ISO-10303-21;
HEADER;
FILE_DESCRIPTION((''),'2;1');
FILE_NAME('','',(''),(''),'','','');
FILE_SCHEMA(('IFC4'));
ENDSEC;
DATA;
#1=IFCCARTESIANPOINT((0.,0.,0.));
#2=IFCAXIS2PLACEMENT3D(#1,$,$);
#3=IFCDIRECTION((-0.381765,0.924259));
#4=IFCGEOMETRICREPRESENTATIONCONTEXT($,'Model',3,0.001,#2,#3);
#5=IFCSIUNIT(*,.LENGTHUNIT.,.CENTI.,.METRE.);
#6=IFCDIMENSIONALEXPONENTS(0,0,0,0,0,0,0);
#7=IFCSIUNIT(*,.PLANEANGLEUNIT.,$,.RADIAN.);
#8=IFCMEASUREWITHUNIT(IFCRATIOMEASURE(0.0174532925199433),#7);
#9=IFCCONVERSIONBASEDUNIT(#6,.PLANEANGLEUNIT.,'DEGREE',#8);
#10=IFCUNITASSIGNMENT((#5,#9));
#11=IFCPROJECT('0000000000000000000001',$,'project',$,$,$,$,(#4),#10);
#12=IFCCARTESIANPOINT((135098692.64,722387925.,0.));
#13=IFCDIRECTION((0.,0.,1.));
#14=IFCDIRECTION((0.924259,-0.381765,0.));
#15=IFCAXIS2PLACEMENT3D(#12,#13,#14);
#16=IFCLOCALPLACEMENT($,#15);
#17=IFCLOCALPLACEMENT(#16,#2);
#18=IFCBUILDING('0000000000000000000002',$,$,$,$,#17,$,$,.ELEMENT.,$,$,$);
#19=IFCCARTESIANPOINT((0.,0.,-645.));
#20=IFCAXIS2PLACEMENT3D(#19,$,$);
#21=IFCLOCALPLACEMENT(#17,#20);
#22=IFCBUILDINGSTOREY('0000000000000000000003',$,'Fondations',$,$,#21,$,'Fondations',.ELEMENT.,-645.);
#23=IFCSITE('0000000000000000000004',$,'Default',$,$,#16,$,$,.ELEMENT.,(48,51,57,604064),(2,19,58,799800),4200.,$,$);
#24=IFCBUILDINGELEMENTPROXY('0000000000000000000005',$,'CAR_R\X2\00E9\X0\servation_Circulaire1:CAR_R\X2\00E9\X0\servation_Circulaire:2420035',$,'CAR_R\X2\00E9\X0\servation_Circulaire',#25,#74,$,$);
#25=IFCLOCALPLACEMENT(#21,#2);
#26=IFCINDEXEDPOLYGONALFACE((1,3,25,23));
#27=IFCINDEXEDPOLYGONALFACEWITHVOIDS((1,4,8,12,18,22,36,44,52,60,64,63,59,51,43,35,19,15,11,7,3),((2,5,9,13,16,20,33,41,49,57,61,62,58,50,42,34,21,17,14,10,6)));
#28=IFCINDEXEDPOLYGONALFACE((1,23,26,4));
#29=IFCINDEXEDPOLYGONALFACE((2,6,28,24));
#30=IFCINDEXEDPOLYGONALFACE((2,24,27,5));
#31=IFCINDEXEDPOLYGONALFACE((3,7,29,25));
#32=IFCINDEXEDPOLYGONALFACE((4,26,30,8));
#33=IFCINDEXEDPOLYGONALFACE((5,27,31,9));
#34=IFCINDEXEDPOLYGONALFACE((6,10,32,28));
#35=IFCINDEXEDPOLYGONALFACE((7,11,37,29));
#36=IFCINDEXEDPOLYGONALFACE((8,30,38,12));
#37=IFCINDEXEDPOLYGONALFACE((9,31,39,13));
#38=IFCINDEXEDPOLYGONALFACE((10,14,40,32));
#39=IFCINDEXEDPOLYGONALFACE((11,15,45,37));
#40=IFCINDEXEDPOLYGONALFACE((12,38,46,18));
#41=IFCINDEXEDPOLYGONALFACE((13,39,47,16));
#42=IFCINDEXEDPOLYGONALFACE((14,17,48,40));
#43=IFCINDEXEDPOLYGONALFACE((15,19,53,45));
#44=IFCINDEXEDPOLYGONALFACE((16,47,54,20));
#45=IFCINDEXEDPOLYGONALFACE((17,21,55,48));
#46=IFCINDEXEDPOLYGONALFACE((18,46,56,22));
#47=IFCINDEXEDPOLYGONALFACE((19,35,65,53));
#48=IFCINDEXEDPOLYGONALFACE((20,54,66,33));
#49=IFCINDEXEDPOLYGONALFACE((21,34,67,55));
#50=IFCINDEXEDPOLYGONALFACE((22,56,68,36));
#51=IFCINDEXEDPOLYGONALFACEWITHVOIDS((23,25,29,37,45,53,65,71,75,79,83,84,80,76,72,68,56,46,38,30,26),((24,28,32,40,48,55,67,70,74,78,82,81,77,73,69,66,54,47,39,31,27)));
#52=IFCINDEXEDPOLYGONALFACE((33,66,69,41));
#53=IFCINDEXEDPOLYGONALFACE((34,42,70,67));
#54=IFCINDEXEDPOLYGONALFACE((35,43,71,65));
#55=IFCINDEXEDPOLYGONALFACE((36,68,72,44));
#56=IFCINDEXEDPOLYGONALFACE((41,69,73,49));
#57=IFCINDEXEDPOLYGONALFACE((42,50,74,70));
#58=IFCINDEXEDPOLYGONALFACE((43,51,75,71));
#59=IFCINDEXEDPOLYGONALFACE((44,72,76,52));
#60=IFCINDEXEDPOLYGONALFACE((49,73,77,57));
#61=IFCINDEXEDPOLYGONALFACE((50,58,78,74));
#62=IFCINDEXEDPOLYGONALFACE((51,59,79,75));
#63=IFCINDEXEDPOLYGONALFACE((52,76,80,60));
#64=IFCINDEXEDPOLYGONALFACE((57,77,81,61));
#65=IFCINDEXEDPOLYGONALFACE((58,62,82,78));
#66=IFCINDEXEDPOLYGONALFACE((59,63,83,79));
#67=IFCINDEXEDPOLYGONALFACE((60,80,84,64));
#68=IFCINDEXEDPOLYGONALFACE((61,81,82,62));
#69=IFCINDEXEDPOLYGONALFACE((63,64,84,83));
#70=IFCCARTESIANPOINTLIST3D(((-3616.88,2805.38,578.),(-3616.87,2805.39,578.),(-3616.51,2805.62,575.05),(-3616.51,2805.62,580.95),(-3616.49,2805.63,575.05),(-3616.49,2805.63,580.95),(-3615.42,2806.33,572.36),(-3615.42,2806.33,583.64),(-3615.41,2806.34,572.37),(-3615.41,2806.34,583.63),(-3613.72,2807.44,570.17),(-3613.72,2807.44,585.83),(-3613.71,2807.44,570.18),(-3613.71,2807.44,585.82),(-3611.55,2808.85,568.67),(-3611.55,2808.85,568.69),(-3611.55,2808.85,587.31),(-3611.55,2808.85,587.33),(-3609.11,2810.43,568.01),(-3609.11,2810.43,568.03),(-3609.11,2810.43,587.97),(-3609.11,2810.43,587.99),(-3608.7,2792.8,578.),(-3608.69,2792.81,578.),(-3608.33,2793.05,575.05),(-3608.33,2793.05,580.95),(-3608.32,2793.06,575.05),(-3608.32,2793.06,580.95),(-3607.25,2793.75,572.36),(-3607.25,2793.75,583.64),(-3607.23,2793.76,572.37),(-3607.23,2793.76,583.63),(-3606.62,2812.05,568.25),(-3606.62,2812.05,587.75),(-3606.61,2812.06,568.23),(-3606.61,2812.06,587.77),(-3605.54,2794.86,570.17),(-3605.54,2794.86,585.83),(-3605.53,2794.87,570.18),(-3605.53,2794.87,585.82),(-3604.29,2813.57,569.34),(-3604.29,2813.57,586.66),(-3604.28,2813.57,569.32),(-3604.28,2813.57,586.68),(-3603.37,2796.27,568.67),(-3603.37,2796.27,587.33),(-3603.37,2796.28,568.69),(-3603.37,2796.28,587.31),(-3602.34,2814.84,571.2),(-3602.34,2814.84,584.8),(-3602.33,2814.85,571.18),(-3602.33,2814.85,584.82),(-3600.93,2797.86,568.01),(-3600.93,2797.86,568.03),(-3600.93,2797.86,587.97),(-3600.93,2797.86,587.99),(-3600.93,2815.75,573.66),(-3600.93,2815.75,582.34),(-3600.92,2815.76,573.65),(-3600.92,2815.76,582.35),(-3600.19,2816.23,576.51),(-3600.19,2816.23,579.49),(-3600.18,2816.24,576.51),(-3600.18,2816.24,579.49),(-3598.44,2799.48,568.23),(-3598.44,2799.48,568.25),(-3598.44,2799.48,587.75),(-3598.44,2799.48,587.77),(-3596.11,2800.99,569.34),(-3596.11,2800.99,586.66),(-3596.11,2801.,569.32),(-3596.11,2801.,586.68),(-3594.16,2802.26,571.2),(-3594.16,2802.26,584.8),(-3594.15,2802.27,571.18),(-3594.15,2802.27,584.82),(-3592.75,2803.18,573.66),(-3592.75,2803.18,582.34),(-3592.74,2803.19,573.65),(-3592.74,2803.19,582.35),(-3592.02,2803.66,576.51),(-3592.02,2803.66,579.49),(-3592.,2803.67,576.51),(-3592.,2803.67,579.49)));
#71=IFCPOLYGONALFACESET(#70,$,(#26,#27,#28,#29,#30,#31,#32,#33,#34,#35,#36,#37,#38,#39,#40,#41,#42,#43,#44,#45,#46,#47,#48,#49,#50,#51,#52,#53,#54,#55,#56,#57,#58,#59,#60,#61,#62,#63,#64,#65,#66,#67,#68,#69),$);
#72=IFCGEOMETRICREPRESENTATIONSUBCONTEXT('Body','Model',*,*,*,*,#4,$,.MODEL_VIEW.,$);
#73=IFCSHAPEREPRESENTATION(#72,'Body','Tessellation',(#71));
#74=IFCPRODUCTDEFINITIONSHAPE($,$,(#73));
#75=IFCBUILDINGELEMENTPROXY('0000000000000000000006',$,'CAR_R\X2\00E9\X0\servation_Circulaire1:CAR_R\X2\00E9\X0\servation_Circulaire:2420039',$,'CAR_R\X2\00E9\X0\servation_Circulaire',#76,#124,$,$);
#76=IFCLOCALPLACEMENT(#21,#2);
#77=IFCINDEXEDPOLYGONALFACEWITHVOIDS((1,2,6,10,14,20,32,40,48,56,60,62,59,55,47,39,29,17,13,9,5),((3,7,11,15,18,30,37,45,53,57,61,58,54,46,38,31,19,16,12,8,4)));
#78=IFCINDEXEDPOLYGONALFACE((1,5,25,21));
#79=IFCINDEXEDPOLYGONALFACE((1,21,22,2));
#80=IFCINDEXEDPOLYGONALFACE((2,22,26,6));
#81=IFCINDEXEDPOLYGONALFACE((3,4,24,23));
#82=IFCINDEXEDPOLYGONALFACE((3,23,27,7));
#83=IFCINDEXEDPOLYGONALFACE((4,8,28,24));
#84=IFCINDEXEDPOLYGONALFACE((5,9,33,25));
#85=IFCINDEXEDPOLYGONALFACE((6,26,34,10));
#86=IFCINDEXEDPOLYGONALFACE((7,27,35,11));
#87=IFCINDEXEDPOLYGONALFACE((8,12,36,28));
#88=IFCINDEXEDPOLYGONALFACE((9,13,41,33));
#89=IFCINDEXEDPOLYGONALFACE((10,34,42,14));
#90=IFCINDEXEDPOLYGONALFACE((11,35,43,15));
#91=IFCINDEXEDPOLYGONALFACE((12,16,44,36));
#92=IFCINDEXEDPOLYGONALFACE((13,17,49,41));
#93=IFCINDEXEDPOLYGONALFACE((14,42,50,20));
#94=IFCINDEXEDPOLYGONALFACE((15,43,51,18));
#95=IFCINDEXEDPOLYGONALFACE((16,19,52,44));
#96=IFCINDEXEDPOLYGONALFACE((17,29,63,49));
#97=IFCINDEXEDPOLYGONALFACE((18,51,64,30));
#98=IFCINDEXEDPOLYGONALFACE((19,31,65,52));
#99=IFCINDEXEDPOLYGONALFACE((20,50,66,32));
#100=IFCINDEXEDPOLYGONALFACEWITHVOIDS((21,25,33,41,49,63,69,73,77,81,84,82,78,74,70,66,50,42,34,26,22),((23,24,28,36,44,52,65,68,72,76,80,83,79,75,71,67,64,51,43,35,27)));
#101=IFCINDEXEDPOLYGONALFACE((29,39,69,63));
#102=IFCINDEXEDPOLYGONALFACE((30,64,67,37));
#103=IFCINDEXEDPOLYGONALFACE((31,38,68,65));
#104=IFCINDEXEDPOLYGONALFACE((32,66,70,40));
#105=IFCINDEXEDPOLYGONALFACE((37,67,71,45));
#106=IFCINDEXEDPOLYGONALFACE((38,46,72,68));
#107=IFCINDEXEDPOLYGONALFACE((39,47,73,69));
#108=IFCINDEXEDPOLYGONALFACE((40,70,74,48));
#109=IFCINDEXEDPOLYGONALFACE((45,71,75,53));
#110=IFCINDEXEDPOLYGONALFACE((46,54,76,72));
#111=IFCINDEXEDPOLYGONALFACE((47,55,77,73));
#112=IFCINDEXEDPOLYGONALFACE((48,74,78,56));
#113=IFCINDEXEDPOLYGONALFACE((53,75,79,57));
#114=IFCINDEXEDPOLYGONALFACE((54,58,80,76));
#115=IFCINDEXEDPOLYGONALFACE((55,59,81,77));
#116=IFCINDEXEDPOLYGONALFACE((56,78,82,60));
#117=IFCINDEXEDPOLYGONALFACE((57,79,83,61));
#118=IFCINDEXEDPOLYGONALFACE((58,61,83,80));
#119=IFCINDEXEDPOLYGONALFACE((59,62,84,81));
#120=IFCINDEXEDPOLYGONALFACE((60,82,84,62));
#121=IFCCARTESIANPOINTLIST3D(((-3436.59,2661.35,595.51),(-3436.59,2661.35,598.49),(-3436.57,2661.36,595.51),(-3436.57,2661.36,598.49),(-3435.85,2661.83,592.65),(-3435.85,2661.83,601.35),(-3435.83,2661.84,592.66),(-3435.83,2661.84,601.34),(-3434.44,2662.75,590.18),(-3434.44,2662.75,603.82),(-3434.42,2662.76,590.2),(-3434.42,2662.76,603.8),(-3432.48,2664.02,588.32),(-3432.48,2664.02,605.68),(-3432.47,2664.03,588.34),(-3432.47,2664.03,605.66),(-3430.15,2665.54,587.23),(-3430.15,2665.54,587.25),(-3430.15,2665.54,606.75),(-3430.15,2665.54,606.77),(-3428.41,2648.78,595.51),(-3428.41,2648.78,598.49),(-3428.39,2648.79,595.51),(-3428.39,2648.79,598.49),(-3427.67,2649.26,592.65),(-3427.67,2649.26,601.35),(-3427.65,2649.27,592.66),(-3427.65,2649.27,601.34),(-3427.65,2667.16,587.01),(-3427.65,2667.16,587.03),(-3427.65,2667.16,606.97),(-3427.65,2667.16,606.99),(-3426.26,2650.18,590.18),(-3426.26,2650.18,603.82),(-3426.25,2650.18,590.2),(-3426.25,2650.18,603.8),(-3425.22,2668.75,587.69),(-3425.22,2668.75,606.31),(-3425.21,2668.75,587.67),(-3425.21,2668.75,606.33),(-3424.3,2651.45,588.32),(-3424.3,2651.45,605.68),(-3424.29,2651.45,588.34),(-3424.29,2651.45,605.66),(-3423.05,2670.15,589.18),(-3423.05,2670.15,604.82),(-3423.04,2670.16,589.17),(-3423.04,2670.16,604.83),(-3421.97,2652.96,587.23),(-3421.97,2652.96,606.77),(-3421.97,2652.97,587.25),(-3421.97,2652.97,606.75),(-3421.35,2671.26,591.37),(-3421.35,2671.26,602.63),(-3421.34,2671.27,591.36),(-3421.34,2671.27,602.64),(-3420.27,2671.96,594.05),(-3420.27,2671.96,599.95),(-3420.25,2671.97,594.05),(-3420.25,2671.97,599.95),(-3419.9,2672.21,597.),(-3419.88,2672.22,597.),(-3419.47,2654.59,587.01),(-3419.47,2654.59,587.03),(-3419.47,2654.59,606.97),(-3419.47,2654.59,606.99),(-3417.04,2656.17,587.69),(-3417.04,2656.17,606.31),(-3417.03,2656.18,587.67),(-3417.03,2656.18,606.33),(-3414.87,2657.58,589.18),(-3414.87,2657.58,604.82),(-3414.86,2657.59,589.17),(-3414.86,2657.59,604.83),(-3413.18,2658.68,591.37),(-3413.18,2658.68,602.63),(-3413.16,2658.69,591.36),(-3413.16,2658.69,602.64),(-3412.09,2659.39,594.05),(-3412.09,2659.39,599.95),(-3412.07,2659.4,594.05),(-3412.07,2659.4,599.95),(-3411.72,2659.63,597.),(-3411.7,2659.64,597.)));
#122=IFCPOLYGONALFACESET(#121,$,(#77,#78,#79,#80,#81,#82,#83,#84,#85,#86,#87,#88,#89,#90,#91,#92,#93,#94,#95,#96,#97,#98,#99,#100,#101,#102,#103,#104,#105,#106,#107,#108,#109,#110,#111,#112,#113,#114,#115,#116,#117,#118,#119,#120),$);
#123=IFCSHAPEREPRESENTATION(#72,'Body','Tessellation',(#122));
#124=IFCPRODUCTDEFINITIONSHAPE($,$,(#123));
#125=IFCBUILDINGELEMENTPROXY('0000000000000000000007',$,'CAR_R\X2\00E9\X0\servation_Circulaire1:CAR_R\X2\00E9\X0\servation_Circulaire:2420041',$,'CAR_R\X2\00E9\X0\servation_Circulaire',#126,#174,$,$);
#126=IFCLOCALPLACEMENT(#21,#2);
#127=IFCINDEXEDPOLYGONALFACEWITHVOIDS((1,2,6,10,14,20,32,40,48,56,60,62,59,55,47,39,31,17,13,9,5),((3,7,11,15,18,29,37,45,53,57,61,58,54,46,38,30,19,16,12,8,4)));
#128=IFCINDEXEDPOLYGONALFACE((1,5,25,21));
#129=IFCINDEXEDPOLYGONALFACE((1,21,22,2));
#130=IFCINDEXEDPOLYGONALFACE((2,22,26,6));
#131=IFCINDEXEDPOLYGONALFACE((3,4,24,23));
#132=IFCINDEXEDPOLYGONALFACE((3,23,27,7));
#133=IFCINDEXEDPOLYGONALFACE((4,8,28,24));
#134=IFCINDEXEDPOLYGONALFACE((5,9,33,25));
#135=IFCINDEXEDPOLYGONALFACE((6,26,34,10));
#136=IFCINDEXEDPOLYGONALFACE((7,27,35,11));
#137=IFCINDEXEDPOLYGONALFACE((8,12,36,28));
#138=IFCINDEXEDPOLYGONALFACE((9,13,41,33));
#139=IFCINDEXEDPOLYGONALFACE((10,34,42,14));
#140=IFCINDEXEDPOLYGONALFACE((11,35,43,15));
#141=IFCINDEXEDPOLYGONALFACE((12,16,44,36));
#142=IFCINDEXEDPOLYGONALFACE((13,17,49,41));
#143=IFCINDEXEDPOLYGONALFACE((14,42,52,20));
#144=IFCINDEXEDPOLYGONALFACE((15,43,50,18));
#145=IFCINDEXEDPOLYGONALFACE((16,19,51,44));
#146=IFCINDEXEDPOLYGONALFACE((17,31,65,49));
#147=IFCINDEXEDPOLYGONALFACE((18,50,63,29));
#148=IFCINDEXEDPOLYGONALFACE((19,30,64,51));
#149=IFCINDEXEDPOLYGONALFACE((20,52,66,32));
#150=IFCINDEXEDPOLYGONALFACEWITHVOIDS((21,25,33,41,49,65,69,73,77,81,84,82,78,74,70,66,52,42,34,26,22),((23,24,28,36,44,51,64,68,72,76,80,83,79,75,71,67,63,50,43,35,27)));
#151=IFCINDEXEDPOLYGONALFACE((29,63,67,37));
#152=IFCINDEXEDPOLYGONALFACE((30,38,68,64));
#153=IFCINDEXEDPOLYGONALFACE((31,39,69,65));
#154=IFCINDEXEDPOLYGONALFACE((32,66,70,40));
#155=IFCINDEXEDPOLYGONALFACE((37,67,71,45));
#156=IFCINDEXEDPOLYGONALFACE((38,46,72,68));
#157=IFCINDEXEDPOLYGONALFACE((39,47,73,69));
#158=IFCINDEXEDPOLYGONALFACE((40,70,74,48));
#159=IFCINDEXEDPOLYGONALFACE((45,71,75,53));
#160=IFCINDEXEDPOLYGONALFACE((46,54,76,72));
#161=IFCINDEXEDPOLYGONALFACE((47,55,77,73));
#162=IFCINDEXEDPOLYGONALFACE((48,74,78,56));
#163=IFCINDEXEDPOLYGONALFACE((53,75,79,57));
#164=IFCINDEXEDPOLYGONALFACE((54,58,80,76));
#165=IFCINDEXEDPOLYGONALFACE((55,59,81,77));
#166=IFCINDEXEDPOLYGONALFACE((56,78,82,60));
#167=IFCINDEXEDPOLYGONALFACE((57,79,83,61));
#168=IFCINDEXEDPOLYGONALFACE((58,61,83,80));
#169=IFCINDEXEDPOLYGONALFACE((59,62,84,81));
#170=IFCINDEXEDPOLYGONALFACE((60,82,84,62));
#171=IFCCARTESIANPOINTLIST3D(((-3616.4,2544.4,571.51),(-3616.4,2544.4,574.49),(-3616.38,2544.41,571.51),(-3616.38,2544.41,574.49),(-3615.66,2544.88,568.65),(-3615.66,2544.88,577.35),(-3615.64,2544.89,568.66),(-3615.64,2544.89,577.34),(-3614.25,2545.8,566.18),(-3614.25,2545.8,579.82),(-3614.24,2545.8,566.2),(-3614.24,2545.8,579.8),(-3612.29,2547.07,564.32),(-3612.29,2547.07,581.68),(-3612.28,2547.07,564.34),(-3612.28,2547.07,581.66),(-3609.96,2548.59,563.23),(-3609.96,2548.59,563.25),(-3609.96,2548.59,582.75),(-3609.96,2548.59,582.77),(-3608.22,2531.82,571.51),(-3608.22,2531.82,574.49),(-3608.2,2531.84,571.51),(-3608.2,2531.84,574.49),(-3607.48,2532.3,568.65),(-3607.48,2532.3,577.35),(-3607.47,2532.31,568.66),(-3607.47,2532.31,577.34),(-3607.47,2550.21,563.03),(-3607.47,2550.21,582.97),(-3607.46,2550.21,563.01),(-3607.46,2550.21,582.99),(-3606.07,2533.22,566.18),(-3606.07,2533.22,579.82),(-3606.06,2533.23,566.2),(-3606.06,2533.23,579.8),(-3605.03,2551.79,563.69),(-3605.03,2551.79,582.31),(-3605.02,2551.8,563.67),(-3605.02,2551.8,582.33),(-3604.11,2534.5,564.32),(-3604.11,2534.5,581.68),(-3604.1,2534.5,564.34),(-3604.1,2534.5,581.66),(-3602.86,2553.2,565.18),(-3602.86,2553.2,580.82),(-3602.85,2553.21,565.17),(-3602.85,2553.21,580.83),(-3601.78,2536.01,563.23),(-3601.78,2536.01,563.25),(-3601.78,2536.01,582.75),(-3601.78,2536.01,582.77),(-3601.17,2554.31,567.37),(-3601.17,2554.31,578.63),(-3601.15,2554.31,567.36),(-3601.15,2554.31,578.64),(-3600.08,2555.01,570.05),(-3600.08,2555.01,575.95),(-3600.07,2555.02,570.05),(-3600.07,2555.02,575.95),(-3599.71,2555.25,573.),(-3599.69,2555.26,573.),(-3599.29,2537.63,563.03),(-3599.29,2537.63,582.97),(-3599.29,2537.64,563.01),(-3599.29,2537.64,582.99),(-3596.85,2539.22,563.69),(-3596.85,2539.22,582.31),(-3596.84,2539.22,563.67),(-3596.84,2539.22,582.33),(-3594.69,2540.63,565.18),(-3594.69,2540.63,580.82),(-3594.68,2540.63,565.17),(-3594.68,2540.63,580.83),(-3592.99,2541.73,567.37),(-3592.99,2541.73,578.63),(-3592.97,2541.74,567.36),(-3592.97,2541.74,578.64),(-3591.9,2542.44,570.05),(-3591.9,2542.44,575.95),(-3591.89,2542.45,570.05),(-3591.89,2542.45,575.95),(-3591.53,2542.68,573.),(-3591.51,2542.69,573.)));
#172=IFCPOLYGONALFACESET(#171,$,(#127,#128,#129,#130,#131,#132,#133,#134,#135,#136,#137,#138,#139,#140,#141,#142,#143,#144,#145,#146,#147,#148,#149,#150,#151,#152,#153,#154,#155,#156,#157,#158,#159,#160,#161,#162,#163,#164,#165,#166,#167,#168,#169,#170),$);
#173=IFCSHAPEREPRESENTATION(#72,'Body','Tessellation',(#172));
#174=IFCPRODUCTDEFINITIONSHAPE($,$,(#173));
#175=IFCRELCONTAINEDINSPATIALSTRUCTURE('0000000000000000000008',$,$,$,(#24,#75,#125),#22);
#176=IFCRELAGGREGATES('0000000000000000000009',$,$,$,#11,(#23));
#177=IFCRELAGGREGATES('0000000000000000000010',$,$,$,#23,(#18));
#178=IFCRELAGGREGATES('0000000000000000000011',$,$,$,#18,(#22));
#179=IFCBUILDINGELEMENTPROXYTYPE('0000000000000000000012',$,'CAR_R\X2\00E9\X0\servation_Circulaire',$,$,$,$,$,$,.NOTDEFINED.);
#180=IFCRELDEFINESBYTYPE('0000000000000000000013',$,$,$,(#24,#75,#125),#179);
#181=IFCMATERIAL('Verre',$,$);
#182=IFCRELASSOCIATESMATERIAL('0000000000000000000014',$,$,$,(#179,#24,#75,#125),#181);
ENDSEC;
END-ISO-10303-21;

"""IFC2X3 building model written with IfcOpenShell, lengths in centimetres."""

from ifc_helpers import new_model, entity, si_unit, converted_unit, direction, frame, frame_2d, origin, place, context, subcontext, project, spatial, hollow_circle, extrude, source, transform, mapped, material, type_object, type_shapes, element, save


model = new_model("IFC2X3")

# Units and contexts
model_context = context("Model", 3, precision=0.001, world=origin(), true_north=direction((-0.381765, 0.924259)))
body_context = subcontext(model_context, "Body", "Model", "MODEL_VIEW")
ifc_project = project(units=[si_unit("LENGTHUNIT", "METRE", prefix="CENTI"), converted_unit("PLANEANGLEUNIT", "DEGREE", entity("IfcRatioMeasure", 0.0174532925199433), si_unit("PLANEANGLEUNIT", "RADIAN"), dimensions=[0, 0, 0, 0, 0, 0, 0])], contexts=[model_context])

# Site, building, storey
site_placement = place(None, frame((135098692.64, 722387925.0, 0.0), z_axis=(0.0, 0.0, 1.0), x_axis=(0.924259, -0.381765, 0.0)))
site = spatial("IfcSite", under=ifc_project, at=site_placement, Name="Default", CompositionType="ELEMENT", RefLatitude=(48, 51, 57, 604064), RefLongitude=(2, 19, 58, 799800), RefElevation=4200.0)
building_placement = place(site_placement, origin())
building = spatial("IfcBuilding", under=site, at=building_placement, CompositionType="ELEMENT")
storey_placement = place(building_placement, frame((0.0, 0.0, -645.0)))
storey = spatial("IfcBuildingStorey", under=building, at=storey_placement, Name="Fondations", LongName="Fondations", CompositionType="ELEMENT", Elevation=-645.0)

# Building element proxies
ifc_material_1 = material(Name="Verre")
building_element_proxy_type_1 = type_object("IfcBuildingElementProxyType", Name="CAR_Réservation_Circulaire", PredefinedType="NOTDEFINED", material=ifc_material_1)
shared_shape_1 = source(origin(), body_context, "Body", "SweptSolid", [
    extrude(hollow_circle(Radius=10.02, WallThickness=0.02, at=frame_2d((0.0, 0.0), x_axis=(1.0, 0.0))), frame((0.0, 0.0, -15.0)), (0.0, 0.0, 1.0), 15.0),
])
type_shapes(building_element_proxy_type_1, [shared_shape_1])
for number, where, z_axis, x_axis, name in (
    (1, (-3608.48, 2810.84, 578.0), (-0.545236, 0.838282, 0.0), (-0.838282, -0.545236, 0.0), "CAR_Réservation_Circulaire1:CAR_Réservation_Circulaire:2420035"),
    (2, (-3420.1, 2654.18, 597.0), (0.545236, -0.838282, 0.0), (0.838282, 0.545236, 0.0), "CAR_Réservation_Circulaire1:CAR_Réservation_Circulaire:2420039"),
    (3, (-3599.91, 2537.23, 573.0), (0.545236, -0.838282, 0.0), (0.838282, 0.545236, 0.0), "CAR_Réservation_Circulaire1:CAR_Réservation_Circulaire:2420041"),
):
    element("IfcBuildingElementProxy", number, at=place(storey_placement, frame(where, z_axis=z_axis, x_axis=x_axis)), inside=storey, type_object=building_element_proxy_type_1, material=ifc_material_1, Name=name, ObjectType="CAR_Réservation_Circulaire", context=body_context, shape_type="MappedRepresentation", body=[
        mapped(shared_shape_1, transform((0.0, 0.0, 0.0), scale=1.0)),
    ])

save(model, "model.ifc")
